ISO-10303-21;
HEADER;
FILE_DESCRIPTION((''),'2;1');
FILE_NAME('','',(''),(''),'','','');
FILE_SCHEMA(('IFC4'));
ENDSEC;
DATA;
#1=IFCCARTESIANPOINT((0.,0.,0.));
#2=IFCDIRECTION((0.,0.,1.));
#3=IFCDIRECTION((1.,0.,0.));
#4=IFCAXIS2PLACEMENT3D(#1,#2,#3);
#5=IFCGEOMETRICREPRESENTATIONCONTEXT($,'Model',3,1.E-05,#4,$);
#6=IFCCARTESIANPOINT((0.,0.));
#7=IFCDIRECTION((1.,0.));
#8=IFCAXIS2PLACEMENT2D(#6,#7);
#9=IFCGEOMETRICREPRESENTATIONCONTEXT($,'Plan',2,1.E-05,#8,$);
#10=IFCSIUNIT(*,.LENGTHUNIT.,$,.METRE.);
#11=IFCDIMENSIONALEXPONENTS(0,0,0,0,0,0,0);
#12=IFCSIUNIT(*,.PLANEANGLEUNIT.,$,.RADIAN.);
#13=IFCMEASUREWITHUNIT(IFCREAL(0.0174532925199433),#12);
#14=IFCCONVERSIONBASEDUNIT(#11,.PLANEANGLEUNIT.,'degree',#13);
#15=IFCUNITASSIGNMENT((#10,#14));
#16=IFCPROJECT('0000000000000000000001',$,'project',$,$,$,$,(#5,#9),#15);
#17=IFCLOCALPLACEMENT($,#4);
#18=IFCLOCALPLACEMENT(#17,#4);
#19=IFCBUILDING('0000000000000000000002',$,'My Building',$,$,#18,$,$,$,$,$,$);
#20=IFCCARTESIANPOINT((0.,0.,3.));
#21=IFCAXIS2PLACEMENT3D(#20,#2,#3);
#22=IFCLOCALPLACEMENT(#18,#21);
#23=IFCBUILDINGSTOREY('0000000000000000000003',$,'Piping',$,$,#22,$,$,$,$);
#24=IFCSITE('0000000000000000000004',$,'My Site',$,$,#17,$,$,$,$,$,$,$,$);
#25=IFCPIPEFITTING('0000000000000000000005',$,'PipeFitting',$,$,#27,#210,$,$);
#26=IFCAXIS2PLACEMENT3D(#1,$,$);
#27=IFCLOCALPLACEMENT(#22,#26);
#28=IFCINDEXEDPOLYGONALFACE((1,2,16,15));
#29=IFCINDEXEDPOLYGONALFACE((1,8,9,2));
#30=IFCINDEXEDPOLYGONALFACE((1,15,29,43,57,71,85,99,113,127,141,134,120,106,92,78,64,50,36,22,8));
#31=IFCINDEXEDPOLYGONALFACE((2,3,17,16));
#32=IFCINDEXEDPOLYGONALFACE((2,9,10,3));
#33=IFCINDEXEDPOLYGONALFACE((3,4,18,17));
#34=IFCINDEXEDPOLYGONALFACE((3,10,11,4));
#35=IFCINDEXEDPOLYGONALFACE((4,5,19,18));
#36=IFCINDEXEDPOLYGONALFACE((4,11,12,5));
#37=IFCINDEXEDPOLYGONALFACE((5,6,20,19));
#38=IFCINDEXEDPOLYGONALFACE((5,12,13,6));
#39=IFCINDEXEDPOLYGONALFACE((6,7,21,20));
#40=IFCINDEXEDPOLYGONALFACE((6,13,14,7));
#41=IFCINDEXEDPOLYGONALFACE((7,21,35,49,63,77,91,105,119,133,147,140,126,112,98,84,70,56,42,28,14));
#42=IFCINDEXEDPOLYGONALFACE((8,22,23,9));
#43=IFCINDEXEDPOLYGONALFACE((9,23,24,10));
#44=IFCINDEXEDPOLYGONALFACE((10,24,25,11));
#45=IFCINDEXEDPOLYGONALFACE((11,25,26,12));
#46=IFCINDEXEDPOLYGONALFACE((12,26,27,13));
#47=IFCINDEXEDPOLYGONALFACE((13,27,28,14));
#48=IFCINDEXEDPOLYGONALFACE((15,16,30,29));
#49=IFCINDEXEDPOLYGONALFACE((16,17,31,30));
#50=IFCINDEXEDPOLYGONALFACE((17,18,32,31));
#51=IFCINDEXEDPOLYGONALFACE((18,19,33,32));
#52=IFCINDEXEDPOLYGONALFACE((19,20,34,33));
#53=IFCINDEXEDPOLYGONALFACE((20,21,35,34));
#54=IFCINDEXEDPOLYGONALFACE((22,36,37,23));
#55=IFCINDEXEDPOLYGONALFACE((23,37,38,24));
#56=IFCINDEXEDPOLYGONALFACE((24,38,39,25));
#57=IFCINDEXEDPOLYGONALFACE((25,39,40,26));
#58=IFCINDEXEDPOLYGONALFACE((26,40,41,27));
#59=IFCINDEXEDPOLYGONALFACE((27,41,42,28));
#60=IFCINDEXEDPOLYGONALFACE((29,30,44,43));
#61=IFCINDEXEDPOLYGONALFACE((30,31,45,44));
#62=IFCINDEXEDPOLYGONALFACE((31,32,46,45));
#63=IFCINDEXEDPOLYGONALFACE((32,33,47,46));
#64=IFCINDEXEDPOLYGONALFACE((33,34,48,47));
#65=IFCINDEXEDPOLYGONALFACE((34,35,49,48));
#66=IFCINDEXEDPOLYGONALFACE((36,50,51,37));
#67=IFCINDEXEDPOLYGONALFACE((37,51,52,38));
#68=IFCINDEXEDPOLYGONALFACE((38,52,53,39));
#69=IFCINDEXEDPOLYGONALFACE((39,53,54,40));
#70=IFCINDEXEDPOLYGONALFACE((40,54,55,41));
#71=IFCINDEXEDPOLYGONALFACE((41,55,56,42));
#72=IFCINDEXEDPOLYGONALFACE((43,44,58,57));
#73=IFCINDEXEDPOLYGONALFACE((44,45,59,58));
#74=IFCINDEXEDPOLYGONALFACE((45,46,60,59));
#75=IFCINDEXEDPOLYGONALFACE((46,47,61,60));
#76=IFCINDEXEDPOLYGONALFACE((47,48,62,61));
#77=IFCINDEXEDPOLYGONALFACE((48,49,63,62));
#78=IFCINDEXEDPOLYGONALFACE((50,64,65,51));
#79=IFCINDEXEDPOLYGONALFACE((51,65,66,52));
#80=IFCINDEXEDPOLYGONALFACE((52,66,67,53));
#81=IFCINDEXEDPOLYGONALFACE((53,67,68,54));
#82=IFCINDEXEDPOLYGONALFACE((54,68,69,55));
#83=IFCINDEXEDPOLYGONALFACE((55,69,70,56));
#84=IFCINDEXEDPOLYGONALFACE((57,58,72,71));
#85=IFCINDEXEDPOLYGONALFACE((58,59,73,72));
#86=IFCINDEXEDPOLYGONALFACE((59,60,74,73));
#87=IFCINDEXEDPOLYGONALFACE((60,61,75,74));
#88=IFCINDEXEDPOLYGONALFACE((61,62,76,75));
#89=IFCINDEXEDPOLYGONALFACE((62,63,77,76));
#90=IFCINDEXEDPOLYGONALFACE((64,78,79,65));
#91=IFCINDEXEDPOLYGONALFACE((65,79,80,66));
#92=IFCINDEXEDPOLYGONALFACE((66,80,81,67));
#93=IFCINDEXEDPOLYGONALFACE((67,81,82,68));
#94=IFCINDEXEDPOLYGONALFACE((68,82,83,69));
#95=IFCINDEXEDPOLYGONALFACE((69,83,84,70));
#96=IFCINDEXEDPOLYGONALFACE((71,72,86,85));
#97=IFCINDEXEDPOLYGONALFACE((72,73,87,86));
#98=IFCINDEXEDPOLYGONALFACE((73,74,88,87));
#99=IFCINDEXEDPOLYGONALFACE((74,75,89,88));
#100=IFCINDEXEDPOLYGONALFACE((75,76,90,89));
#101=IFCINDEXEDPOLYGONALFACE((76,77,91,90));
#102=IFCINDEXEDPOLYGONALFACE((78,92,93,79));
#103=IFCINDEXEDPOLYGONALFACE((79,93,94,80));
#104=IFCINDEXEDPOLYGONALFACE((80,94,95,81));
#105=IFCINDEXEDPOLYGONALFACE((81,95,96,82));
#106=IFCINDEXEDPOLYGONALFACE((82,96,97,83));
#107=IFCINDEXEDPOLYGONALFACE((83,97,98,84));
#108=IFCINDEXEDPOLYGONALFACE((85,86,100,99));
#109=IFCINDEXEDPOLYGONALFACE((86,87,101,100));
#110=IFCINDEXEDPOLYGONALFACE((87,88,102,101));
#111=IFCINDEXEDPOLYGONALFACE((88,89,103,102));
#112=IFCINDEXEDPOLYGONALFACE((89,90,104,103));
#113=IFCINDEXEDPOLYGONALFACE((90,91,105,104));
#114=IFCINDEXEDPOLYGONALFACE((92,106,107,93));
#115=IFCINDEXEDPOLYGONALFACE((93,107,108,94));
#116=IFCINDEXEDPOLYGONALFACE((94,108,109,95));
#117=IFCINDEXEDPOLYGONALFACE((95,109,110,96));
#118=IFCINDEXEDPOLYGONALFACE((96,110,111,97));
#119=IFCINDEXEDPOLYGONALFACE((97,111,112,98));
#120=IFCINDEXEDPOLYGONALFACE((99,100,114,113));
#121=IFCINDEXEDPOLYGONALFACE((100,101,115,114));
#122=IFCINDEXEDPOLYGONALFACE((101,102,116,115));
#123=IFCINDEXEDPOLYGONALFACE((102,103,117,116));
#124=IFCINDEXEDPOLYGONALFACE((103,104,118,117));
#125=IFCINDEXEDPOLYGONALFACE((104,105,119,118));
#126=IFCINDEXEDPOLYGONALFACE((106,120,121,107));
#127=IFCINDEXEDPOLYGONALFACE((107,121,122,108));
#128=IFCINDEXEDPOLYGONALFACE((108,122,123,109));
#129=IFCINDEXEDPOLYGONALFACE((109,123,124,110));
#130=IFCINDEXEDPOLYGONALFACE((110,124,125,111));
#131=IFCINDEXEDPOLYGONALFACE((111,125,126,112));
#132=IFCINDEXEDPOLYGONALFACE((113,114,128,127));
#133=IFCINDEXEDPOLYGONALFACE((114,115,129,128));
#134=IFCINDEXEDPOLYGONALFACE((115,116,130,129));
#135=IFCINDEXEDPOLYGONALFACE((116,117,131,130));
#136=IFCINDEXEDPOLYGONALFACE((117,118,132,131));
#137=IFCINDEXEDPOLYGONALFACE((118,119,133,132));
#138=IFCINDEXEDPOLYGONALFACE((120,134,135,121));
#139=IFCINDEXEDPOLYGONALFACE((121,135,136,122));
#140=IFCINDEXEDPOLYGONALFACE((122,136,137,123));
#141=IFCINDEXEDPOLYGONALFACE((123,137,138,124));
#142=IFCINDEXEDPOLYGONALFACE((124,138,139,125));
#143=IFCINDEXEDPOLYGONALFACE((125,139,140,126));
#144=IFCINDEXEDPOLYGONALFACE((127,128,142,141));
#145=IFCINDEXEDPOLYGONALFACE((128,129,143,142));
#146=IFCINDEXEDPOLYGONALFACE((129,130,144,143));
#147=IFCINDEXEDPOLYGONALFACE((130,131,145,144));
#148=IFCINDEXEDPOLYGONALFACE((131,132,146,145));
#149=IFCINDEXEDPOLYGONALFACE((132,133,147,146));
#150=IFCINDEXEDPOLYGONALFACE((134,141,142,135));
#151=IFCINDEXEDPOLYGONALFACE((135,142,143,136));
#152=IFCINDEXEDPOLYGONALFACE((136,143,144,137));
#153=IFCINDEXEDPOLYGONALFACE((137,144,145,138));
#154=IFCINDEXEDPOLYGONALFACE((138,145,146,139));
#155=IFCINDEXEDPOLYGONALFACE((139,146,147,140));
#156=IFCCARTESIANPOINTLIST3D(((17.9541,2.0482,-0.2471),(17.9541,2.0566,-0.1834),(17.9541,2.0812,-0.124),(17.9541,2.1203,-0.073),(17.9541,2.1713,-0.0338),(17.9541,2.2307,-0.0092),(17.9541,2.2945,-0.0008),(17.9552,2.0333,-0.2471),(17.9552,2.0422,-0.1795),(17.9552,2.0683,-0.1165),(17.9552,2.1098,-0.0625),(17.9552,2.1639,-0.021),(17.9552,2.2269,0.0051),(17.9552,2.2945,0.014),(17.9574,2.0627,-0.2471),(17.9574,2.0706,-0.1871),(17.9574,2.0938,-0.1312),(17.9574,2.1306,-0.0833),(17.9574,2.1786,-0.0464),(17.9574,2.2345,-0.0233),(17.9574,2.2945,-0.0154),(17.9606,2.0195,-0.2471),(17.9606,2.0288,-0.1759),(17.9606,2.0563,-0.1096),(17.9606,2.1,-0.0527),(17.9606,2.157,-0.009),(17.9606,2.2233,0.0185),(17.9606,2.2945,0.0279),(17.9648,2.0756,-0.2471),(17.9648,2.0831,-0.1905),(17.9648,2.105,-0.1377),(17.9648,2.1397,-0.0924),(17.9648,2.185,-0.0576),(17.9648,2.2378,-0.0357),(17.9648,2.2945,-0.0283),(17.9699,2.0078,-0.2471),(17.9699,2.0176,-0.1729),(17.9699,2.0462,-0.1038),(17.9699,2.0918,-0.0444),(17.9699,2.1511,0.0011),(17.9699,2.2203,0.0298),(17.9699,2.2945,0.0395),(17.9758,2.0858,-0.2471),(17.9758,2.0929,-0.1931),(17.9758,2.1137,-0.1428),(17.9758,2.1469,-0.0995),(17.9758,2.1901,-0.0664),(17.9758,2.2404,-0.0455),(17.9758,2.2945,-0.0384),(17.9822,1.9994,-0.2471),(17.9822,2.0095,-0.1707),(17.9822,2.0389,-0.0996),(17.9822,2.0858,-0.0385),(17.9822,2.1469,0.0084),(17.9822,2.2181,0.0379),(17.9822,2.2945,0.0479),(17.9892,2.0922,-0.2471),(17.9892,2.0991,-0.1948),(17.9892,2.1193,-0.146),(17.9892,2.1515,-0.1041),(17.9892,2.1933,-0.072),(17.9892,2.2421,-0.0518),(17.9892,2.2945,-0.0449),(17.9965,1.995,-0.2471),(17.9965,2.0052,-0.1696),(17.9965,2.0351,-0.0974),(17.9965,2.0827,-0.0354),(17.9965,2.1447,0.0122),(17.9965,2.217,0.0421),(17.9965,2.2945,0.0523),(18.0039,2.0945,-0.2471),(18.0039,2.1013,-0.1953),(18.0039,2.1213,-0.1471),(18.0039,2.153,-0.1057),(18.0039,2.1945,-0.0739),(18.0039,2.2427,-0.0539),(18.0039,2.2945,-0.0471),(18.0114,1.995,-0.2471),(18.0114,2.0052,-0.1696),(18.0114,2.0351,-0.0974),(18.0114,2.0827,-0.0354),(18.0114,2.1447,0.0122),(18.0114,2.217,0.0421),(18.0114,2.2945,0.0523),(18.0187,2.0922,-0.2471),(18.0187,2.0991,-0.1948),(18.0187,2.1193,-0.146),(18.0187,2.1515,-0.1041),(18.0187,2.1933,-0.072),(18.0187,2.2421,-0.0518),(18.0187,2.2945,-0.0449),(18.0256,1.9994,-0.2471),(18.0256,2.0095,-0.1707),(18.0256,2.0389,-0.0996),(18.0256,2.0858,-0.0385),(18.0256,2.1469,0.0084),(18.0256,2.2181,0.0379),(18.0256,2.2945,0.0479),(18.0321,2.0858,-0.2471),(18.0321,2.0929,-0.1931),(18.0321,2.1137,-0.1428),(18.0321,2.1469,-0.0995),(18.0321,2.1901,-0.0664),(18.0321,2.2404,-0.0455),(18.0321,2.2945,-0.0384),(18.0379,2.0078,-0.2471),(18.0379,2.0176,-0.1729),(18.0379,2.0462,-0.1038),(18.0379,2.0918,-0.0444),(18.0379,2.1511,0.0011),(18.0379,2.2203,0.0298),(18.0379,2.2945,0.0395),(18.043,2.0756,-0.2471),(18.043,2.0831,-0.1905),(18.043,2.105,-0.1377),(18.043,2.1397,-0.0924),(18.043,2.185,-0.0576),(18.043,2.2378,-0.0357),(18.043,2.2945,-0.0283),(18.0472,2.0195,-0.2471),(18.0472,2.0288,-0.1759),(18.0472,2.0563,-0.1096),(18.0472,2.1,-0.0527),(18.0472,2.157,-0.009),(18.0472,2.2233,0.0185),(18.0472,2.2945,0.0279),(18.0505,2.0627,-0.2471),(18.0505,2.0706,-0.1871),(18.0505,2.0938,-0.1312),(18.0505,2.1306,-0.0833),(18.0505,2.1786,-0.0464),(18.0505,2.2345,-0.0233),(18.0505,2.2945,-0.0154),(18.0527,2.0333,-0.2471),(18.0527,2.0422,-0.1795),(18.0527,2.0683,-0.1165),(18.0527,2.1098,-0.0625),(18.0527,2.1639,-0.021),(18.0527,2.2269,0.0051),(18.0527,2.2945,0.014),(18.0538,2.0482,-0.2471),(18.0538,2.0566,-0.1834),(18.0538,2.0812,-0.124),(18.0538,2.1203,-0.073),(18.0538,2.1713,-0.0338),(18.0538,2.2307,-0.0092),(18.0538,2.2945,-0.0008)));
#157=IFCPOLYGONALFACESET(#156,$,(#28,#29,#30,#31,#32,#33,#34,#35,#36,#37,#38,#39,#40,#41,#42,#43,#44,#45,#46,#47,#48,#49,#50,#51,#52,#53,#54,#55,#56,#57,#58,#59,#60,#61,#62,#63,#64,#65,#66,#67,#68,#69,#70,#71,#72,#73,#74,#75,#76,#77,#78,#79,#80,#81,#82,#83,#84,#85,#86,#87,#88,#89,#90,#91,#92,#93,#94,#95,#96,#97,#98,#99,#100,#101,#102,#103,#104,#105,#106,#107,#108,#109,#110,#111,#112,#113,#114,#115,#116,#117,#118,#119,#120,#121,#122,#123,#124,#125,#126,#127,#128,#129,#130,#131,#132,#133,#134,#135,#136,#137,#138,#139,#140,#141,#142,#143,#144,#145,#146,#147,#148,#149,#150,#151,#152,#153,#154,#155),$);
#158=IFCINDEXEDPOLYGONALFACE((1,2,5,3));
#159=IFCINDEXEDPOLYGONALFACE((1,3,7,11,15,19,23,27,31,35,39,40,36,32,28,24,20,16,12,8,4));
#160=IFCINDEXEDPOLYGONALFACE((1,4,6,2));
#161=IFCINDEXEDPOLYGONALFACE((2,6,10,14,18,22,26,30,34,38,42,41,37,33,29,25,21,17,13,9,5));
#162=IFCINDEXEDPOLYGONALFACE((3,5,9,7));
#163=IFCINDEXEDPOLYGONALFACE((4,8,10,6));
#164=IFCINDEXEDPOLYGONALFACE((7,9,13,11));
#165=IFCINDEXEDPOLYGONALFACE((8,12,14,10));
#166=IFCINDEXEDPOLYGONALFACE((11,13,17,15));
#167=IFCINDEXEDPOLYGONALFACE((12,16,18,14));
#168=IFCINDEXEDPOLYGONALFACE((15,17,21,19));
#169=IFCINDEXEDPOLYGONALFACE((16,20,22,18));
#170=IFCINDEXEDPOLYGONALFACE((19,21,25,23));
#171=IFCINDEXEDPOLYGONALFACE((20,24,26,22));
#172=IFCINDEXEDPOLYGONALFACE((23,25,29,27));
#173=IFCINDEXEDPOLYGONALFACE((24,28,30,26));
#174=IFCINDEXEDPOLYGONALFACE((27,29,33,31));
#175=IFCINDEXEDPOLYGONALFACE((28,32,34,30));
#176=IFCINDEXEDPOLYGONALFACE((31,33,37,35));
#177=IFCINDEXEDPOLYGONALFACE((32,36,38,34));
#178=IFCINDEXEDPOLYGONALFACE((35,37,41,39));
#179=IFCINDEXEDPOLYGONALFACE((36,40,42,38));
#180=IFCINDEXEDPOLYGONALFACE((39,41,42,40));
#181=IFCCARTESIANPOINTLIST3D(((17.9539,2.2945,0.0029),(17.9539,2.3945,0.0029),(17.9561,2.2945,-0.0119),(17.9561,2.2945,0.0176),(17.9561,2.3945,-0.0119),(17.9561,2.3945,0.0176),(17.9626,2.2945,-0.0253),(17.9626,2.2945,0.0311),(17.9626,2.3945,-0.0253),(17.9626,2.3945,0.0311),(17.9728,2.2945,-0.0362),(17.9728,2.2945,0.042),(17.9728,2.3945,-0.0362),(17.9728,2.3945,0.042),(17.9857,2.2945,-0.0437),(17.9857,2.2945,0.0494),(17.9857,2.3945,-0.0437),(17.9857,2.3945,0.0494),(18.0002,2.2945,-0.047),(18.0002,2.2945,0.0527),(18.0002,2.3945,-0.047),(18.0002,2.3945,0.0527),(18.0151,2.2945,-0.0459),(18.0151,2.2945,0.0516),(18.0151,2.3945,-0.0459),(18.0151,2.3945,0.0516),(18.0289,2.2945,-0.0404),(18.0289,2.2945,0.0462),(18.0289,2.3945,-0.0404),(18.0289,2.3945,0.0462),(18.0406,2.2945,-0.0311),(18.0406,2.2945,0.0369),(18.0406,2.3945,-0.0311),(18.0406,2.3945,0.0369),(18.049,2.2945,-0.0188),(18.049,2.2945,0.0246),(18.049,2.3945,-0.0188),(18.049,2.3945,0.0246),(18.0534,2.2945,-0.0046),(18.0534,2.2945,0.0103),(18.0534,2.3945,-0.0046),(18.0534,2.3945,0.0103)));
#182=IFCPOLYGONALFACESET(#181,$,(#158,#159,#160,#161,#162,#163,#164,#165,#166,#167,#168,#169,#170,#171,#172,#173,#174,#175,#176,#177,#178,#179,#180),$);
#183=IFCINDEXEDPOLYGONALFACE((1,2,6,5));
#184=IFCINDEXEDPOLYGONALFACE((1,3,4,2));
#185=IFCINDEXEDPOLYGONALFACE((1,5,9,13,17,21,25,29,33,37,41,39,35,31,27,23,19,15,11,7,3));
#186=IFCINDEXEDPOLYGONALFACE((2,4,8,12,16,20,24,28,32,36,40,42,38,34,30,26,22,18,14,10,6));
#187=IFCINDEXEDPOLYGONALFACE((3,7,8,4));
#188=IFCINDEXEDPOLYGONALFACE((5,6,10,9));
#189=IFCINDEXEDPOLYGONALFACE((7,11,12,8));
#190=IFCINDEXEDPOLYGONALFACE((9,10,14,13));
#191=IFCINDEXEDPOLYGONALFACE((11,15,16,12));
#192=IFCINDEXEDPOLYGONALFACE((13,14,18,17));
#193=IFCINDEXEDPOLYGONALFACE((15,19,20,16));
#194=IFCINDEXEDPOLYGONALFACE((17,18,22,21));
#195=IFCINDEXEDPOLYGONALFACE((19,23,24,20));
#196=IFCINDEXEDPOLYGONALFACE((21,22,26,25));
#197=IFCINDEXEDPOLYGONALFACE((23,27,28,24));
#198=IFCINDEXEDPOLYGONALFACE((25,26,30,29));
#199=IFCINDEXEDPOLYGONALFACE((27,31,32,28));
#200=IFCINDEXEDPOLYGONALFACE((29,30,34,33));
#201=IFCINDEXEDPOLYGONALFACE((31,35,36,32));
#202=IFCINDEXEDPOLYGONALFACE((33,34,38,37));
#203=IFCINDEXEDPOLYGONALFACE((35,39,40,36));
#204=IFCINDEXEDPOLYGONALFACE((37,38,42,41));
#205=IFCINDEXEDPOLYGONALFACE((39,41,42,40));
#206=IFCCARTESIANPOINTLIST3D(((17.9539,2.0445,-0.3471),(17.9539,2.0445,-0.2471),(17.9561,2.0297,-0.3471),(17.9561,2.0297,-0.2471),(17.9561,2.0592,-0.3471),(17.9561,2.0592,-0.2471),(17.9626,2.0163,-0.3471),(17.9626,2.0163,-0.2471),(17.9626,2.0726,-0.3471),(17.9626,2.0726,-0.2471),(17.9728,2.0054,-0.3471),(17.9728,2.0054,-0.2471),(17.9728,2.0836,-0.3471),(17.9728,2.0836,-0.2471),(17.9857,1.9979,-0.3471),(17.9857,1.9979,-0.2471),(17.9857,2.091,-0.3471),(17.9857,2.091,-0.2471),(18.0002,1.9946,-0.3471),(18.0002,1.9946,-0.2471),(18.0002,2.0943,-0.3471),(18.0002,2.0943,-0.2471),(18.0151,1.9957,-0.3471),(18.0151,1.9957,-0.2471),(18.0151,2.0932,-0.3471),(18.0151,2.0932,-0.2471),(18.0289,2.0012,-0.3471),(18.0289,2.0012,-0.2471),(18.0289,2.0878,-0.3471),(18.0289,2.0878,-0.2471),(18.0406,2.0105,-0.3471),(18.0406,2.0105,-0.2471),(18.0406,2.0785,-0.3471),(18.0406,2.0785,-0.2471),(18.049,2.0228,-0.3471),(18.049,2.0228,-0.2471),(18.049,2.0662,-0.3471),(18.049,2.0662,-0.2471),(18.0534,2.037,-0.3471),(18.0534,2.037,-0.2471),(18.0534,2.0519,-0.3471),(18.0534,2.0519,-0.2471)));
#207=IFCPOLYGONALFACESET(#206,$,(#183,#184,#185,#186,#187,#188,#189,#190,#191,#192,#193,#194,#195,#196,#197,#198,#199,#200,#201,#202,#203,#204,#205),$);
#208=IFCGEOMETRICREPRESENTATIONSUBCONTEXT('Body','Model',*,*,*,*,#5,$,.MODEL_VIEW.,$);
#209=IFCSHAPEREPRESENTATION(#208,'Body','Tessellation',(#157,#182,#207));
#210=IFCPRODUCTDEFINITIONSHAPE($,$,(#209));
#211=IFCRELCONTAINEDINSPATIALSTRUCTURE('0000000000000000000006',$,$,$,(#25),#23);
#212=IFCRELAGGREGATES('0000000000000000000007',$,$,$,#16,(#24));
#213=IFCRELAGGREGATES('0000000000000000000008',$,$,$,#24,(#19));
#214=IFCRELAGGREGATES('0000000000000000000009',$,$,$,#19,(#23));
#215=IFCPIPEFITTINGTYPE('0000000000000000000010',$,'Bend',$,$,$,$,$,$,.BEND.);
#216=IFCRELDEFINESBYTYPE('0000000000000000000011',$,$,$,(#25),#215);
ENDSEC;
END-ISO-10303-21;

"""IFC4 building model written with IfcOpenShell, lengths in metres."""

from ifc_helpers import new_model, entity, si_unit, converted_unit, frame, origin_with_axes, origin_2d_with_axis, place, context, subcontext, project, spatial, circle, extrude, source, transform, mapped, type_object, type_shapes, element, save


model = new_model("IFC4")

# Units and contexts
model_context = context("Model", 3, precision=1e-05, world=origin_with_axes())
plan_context = context("Plan", 2, precision=1e-05, world=origin_2d_with_axis())
body_context = subcontext(model_context, "Body", "Model", "MODEL_VIEW")
ifc_project = project(units=[si_unit("LENGTHUNIT", "METRE"), converted_unit("PLANEANGLEUNIT", "degree", entity("IfcReal", 0.0174532925199433), si_unit("PLANEANGLEUNIT", "RADIAN"), dimensions=[0, 0, 0, 0, 0, 0, 0])], contexts=[model_context, plan_context])

# Site, building, storey
site_placement = place(None, origin_with_axes())
site = spatial("IfcSite", under=ifc_project, at=site_placement, Name="My Site")
building_placement = place(site_placement, origin_with_axes())
building = spatial("IfcBuilding", under=site, at=building_placement, Name="My Building")
storey_placement = place(building_placement, frame((0.0, 0.0, 3.0), z_axis=(0.0, 0.0, 1.0), x_axis=(1.0, 0.0, 0.0)))
storey = spatial("IfcBuildingStorey", under=building, at=storey_placement, Name="Piping")

# Pipe fitting
pipe_fitting_type_1 = type_object("IfcPipeFittingType", Name="Bend", PredefinedType="BEND")
shared_shape = source(origin_with_axes(), body_context, "Body", "SolidModel", [
    entity("IfcSweptDiskSolid", entity("IfcIndexedPolyCurve", entity("IfcCartesianPointList3D", [[0.0, 0.0, -0.1], [0.0, -0.0732, -0.2768], [0.0, -0.25, -0.35]]), [entity("IfcArcIndex", [1, 2, 3])]), 0.05),
    extrude(circle(Radius=0.05), origin_with_axes(), (0.0, 0.0, -1.0), 0.1),
    extrude(circle(Radius=0.05), frame((0.0, -0.25, -0.35), z_axis=(0.0, -1.0, 0.0), x_axis=(1.0, 0.0, 0.0)), (0.0, 0.0, 1.0), 0.1),
])
type_shapes(pipe_fitting_type_1, [shared_shape])
for number, where, z_axis, x_axis, name in (
    (1, (18.0039, 2.3945, 0.0029), (0.0, 1.0, 0.0), (-1.0, 0.0, 0.0), "PipeFitting"),
):
    element("IfcPipeFitting", number, at=place(storey_placement, frame(where, z_axis=z_axis, x_axis=x_axis)), inside=storey, type_object=pipe_fitting_type_1, Name=name, context=body_context, shape_type="MappedRepresentation", body=[
        mapped(shared_shape, transform((0.0, 0.0, 0.0), x_axis=(1.0, 0.0, 0.0), y_axis=(0.0, 1.0, 0.0), z_axis=(0.0, 0.0, 1.0), scale=1.0)),
    ])

save(model, "model.ifc")
